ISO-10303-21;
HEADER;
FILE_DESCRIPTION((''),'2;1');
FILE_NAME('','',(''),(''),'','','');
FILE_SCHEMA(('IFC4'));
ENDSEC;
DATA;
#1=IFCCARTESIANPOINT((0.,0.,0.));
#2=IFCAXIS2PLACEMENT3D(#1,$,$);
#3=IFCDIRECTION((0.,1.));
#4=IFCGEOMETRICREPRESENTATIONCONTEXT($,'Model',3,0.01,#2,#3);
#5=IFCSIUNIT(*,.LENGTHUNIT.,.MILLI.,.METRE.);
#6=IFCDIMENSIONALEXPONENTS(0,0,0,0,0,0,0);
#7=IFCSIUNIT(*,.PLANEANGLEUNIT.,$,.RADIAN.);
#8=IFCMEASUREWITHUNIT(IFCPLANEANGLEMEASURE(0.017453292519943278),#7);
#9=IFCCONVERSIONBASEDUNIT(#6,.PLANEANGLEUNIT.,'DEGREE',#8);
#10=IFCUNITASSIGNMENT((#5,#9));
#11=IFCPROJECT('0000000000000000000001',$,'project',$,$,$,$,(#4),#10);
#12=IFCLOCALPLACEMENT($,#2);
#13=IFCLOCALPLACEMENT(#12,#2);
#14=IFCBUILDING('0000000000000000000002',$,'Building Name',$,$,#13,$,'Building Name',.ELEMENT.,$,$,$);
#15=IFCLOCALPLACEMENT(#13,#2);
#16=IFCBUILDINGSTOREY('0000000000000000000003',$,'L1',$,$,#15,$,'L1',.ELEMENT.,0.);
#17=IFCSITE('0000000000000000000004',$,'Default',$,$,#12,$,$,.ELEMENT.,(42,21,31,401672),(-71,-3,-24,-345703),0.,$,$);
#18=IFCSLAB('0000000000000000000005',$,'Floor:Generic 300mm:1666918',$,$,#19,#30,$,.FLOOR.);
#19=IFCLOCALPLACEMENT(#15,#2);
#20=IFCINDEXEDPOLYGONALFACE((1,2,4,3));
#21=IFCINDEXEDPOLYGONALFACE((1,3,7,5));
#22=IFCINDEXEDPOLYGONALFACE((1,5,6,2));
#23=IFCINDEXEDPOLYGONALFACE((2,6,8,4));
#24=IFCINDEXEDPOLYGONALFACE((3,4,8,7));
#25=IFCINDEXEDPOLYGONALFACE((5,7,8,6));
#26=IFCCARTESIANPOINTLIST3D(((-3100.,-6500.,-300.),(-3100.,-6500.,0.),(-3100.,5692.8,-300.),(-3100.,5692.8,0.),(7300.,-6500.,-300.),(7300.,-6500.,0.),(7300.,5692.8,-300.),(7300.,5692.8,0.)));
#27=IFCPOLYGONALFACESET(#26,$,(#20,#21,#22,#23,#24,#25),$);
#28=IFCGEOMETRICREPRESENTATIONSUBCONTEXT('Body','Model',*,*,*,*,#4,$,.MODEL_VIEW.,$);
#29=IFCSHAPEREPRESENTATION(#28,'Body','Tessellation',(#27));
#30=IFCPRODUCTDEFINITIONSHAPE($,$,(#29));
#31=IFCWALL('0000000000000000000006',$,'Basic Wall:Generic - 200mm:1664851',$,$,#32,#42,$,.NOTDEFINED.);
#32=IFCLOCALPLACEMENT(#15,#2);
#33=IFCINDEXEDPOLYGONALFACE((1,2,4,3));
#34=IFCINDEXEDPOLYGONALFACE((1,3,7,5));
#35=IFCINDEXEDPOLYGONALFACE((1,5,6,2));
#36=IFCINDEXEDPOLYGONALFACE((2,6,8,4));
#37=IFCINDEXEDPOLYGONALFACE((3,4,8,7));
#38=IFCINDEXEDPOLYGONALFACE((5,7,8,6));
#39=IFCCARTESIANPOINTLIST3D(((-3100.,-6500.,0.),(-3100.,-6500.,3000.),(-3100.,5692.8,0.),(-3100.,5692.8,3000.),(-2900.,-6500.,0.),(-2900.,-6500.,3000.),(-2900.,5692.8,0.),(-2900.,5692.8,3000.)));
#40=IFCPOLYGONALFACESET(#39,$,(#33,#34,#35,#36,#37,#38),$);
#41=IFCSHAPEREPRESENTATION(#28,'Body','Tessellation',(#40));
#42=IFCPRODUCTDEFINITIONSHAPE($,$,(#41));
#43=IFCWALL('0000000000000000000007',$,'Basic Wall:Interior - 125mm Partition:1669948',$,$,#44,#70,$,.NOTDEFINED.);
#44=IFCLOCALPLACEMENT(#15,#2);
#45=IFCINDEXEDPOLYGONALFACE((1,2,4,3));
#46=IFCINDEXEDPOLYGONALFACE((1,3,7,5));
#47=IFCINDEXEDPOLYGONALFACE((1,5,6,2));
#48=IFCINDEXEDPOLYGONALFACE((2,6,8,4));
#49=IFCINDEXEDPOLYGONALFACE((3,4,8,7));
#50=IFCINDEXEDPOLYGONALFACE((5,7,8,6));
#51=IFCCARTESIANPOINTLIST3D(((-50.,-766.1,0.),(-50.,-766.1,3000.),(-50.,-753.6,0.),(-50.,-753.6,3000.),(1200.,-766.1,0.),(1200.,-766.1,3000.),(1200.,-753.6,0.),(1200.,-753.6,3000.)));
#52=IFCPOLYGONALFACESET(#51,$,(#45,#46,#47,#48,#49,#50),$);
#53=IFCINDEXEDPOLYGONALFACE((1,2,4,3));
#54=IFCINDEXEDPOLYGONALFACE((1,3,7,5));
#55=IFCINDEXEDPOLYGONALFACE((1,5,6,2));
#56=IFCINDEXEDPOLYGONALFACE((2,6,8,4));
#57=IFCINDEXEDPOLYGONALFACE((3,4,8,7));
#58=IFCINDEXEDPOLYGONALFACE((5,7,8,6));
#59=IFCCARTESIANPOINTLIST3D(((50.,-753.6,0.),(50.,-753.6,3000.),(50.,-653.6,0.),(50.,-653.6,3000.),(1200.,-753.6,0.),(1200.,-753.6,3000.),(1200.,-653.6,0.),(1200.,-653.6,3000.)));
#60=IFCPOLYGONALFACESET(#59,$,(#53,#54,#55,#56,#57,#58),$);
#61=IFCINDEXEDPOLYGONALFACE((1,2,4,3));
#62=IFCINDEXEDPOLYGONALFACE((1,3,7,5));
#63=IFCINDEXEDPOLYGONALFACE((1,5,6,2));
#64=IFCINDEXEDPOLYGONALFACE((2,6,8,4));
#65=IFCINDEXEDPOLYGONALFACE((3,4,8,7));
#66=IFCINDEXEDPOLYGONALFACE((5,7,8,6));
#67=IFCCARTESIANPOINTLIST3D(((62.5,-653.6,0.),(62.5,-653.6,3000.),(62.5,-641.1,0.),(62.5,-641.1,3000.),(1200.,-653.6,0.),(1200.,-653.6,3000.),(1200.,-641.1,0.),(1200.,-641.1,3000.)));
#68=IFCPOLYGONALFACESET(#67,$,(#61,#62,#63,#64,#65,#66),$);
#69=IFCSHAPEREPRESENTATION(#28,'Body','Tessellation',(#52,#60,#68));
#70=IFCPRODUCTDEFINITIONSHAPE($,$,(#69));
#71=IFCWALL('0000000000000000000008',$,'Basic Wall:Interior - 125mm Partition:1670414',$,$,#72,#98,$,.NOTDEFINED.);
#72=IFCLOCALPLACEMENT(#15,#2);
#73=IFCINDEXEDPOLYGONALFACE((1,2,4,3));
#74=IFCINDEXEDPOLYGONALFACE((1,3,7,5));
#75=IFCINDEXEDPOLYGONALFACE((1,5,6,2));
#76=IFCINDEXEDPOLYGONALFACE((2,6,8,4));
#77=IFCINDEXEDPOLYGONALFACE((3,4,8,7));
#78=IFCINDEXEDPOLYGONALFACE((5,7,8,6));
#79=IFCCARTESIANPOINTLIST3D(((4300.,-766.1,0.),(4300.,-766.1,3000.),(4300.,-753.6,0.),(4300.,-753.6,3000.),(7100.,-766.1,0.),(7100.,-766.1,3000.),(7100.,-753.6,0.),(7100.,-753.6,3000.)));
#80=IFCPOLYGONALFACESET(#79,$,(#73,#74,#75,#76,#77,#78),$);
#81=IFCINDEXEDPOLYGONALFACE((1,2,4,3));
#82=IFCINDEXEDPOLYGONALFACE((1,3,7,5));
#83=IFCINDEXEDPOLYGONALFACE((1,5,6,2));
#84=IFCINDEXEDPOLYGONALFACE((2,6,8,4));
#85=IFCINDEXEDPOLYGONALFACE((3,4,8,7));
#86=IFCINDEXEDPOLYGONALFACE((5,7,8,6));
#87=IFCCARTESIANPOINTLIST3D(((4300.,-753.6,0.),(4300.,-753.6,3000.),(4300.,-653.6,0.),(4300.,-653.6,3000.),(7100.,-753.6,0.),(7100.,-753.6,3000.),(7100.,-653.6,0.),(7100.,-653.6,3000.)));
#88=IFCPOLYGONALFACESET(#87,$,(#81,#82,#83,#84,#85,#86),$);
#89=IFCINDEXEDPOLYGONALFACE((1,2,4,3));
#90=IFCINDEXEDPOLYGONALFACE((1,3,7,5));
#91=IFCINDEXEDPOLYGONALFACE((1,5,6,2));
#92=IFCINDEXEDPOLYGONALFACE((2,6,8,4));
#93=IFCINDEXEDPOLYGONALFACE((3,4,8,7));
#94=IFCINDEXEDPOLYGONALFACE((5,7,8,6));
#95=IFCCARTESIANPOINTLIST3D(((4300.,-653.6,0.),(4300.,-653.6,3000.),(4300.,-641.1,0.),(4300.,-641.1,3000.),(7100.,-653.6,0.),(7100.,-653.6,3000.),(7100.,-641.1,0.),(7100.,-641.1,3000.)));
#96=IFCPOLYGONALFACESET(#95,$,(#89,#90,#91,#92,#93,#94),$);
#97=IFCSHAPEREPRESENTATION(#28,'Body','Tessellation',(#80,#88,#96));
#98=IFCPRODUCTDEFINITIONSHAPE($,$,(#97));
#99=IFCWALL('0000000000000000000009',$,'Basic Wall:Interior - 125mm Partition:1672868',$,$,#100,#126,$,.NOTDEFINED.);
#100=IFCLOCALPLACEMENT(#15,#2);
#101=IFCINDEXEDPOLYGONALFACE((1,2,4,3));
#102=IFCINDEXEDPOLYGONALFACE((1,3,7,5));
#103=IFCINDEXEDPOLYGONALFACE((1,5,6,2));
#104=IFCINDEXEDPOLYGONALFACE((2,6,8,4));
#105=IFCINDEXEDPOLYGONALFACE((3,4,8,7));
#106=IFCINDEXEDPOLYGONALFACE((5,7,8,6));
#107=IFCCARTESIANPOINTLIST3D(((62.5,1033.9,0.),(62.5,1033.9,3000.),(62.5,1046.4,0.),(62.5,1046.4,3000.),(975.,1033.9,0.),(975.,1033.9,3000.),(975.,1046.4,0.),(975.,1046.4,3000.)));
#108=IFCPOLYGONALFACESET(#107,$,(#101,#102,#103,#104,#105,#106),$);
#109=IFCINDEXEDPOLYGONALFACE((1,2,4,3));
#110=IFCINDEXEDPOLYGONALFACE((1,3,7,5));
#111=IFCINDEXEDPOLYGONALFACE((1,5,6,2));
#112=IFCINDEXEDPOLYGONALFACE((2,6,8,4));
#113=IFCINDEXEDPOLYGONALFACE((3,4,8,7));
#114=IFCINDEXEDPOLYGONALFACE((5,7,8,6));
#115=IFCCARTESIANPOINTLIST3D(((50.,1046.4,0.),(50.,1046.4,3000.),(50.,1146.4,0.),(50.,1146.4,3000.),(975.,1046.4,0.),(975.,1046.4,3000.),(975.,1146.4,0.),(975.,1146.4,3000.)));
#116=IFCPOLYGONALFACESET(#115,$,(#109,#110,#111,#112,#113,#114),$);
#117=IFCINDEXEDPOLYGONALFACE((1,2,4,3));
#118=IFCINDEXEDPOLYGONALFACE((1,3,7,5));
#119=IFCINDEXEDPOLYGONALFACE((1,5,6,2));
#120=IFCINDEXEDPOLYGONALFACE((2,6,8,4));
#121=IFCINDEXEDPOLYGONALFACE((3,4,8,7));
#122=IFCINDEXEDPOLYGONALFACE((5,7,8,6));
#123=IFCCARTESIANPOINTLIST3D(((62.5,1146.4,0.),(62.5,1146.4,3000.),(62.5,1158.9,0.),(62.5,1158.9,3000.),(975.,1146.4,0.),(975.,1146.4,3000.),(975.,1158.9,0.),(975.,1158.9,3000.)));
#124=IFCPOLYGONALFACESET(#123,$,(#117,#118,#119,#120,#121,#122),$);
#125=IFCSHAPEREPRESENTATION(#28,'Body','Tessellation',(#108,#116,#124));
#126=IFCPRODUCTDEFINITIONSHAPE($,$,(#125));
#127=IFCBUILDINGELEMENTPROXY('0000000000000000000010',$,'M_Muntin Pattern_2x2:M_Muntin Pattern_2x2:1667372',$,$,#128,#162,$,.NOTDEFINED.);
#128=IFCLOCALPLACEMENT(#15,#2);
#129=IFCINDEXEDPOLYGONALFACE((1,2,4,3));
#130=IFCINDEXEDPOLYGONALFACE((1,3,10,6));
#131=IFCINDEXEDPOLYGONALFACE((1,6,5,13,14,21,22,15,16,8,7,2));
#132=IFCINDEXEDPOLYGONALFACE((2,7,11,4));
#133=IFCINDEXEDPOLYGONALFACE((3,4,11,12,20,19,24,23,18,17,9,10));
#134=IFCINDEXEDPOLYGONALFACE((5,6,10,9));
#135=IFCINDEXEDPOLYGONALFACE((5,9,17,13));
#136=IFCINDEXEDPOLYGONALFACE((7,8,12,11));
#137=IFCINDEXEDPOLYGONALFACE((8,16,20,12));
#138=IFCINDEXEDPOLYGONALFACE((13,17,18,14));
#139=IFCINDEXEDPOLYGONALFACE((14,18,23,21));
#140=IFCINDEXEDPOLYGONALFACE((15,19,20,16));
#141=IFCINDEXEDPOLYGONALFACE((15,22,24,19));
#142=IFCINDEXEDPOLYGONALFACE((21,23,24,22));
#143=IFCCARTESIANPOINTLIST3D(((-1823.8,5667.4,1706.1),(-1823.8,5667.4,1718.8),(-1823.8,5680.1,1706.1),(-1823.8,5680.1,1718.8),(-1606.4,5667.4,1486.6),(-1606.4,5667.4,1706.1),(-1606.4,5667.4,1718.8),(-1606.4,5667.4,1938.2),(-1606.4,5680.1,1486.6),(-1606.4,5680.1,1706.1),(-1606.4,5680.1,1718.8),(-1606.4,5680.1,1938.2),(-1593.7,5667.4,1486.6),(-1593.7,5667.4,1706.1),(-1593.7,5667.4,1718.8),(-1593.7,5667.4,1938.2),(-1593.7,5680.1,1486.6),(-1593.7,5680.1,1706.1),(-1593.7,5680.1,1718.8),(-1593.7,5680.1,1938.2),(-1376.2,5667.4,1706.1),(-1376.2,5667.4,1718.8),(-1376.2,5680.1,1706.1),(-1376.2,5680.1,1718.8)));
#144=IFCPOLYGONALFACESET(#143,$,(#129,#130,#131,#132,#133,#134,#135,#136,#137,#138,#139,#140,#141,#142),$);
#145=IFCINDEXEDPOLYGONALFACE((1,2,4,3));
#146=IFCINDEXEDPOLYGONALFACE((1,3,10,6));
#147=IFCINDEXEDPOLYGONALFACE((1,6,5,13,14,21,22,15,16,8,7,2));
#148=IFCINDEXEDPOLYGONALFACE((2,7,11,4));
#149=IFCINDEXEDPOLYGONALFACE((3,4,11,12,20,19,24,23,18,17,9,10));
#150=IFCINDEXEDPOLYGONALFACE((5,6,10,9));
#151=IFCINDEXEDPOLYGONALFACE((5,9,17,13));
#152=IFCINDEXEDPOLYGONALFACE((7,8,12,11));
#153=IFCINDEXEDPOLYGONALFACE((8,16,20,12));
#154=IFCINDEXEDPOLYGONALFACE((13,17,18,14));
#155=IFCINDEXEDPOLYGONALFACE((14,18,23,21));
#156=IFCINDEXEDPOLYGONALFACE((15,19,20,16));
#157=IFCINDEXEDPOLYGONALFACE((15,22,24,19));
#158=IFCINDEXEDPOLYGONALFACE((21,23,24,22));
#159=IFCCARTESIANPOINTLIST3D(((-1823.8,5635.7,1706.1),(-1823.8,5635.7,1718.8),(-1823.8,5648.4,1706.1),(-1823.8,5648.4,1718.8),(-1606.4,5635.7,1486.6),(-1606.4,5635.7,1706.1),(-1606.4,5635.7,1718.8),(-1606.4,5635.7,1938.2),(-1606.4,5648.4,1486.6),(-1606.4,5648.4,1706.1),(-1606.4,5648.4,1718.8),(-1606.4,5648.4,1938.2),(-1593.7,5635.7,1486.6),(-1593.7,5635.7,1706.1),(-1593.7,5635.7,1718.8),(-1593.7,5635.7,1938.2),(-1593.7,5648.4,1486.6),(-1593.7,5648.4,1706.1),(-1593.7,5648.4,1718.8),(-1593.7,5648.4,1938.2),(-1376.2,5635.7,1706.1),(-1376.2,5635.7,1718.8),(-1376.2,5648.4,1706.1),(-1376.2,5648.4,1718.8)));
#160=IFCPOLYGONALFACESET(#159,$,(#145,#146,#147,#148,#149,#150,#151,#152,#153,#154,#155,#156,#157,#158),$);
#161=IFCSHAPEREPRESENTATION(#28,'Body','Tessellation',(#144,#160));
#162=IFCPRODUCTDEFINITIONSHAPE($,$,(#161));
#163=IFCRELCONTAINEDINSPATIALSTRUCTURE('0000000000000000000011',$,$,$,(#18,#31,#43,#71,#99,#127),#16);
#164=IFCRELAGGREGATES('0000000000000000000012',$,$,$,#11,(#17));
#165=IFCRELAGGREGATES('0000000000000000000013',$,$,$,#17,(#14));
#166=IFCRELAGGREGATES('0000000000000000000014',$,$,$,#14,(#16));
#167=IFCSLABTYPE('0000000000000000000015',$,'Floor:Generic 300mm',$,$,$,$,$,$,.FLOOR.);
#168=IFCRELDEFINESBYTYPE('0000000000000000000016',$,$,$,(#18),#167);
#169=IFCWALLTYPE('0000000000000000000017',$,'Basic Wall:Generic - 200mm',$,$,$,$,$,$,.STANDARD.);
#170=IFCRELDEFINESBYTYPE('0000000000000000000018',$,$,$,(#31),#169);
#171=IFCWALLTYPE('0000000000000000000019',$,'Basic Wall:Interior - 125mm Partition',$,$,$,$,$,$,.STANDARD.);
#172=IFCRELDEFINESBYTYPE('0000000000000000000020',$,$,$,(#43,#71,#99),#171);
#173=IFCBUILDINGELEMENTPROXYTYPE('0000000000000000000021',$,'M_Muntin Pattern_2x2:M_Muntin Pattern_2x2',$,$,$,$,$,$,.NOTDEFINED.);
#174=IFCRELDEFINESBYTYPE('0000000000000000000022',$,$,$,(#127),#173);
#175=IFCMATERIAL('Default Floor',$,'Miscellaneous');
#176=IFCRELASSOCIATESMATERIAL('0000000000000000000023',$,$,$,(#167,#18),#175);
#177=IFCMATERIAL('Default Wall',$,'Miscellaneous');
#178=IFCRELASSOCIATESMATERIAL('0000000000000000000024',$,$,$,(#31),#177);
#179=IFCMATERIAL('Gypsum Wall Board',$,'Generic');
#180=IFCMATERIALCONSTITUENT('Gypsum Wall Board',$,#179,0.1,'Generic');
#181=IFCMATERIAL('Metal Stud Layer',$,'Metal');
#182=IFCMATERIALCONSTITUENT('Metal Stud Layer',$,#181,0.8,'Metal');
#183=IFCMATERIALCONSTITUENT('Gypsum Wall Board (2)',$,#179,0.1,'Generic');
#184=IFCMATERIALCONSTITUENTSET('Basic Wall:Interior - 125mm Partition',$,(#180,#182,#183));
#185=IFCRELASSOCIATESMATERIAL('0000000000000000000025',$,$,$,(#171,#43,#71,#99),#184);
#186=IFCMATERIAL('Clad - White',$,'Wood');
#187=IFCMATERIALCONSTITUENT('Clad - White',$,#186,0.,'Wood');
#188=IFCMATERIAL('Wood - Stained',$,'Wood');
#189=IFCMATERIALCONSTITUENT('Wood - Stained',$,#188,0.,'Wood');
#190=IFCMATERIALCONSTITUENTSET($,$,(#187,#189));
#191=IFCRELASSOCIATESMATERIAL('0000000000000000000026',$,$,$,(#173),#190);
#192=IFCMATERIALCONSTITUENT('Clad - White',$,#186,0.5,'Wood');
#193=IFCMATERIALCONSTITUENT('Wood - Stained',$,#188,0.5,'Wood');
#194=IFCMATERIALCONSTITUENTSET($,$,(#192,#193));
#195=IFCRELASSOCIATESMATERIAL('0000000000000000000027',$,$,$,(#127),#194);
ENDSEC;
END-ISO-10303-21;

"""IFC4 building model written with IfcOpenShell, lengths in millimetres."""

from ifc_helpers import new_model, entity, si_unit, converted_unit, direction, frame, origin, place, context, subcontext, project, spatial, indexed_curve, outline, extrude, source, transform, mapped, material, constituent, constituent_set, type_object, type_shapes, element, save


model = new_model("IFC4")

# Units and contexts
model_context = context("Model", 3, precision=0.01, world=origin(), true_north=direction((0.0, 1.0)))
body_context = subcontext(model_context, "Body", "Model", "MODEL_VIEW")
ifc_project = project(units=[si_unit("LENGTHUNIT", "METRE", prefix="MILLI"), converted_unit("PLANEANGLEUNIT", "DEGREE", entity("IfcPlaneAngleMeasure", 0.017453292519943278), si_unit("PLANEANGLEUNIT", "RADIAN"), dimensions=[0, 0, 0, 0, 0, 0, 0])], contexts=[model_context])

# Site, building, storey
site_placement = place(None, origin())
site = spatial("IfcSite", under=ifc_project, at=site_placement, Name="Default", CompositionType="ELEMENT", RefLatitude=(42, 21, 31, 401672), RefLongitude=(-71, -3, -24, -345703), RefElevation=0.0)
building_placement = place(site_placement, origin())
building = spatial("IfcBuilding", under=site, at=building_placement, Name="Building Name", LongName="Building Name", CompositionType="ELEMENT")
storey_placement = place(building_placement, origin())
storey = spatial("IfcBuildingStorey", under=building, at=storey_placement, Name="L1", LongName="L1", CompositionType="ELEMENT", Elevation=0.0)

# Slab
ifc_material_1 = material(Name="Default Floor", Category="Miscellaneous")
slab_type = type_object("IfcSlabType", Name="Floor:Generic 300mm", PredefinedType="FLOOR", material=ifc_material_1)
slab_placement = place(storey_placement, origin())
element("IfcSlab", 1, at=slab_placement, inside=storey, type_object=slab_type, material=ifc_material_1, Name="Floor:Generic 300mm:1666918", PredefinedType="FLOOR", context=body_context, shape_type="SweptSolid", body=[
    extrude(outline(indexed_curve([(-6096.4, -5200.0), (6096.4, -5200.0), (6096.4, 5200.0), (-6096.4, 5200.0), (-6096.4, -5200.0)], self_intersect=False)), frame((2100.0, -403.6, 0.0), z_axis=(0.0, 0.0, -1.0), x_axis=(0.0, 1.0, 0.0)), (0.0, 0.0, 1.0), 300.0),
])

# Wall
ifc_material_2 = material(Name="Default Wall", Category="Miscellaneous")
wall_type_1 = type_object("IfcWallType", Name="Basic Wall:Generic - 200mm", PredefinedType="STANDARD")
wall_1_placement = place(storey_placement, frame((-3000.0, 5692.8, 0.0), z_axis=(0.0, 0.0, 1.0), x_axis=(0.0, -1.0, 0.0)))
element("IfcWall", 2, at=wall_1_placement, inside=storey, type_object=wall_type_1, material=ifc_material_2, Name="Basic Wall:Generic - 200mm:1664851", PredefinedType="NOTDEFINED", context=body_context, shape_type="SweptSolid", body=[
    extrude(outline(indexed_curve([(12192.8, 100.0), (0.0, 100.0), (0.0, -100.0), (12192.8, -100.0), (12192.8, 100.0)], self_intersect=False)), origin(), (0.0, 0.0, 1.0), 3000.0),
])

# Shared definitions
ifc_material_3 = material(Name="Gypsum Wall Board", Category="Generic")
ifc_constituent_1 = constituent(ifc_material_3, Name="Gypsum Wall Board", Category="Generic", fraction=0.1)
ifc_material_4 = material(Name="Metal Stud Layer", Category="Metal")
ifc_constituent_2 = constituent(ifc_material_4, Name="Metal Stud Layer", Category="Metal", fraction=0.8)
ifc_constituent_3 = constituent(ifc_material_3, Name="Gypsum Wall Board (2)", Category="Generic", fraction=0.1)
ifc_constituent_set_1 = constituent_set(constituents=[ifc_constituent_1, ifc_constituent_2, ifc_constituent_3], Name="Basic Wall:Interior - 125mm Partition")
wall_type_2 = type_object("IfcWallType", Name="Basic Wall:Interior - 125mm Partition", PredefinedType="STANDARD", material=ifc_constituent_set_1)

# Walls
wall_2_placement = place(storey_placement, frame((62.5, -703.6, 0.0)))
element("IfcWall", 3, at=wall_2_placement, inside=storey, type_object=wall_type_2, material=ifc_constituent_set_1, Name="Basic Wall:Interior - 125mm Partition:1669948", PredefinedType="NOTDEFINED", context=body_context, shape_type="SweptSolid", body=[
    extrude(outline(indexed_curve([(-6.3, -625.0), (6.2, -625.0), (6.3, 625.0), (-6.2, 625.0), (-6.3, -625.0)], self_intersect=False)), frame((512.5, -56.2, 0.0), z_axis=(0.0, 0.0, 1.0), x_axis=(0.0, 1.0, 0.0)), (0.0, 0.0, 1.0), 3000.0),
    extrude(outline(indexed_curve([(-575.0, -50.0), (575.0, -50.0), (575.0, 50.0), (-575.0, 50.0), (-575.0, -50.0)], self_intersect=False)), frame((562.5, 0.0, 0.0)), (0.0, 0.0, 1.0), 3000.0),
    extrude(outline(indexed_curve([(-6.3, -568.7), (6.2, -568.7), (6.3, 568.7), (-6.2, 568.7), (-6.3, -568.7)], self_intersect=False)), frame((568.7, 56.3, 0.0), z_axis=(0.0, 0.0, 1.0), x_axis=(0.0, -1.0, 0.0)), (0.0, 0.0, 1.0), 3000.0),
])
wall_3_placement = place(storey_placement, frame((7100.0, -703.6, 0.0), z_axis=(0.0, 0.0, 1.0), x_axis=(-1.0, 0.0, 0.0)))
element("IfcWall", 4, at=wall_3_placement, inside=storey, type_object=wall_type_2, material=ifc_constituent_set_1, Name="Basic Wall:Interior - 125mm Partition:1670414", PredefinedType="NOTDEFINED", context=body_context, shape_type="SweptSolid", body=[
    extrude(outline(indexed_curve([(-6.2, -1400.0), (6.3, -1400.0), (6.2, 1400.0), (-6.3, 1400.0), (-6.2, -1400.0)], self_intersect=False)), frame((1400.0, 56.3, 0.0), z_axis=(0.0, 0.0, 1.0), x_axis=(0.0, -1.0, 0.0)), (0.0, 0.0, 1.0), 3000.0),
    extrude(outline(indexed_curve([(-1400.0, -50.0), (1400.0, -50.0), (1400.0, 50.0), (-1400.0, 50.0), (-1400.0, -50.0)], self_intersect=False)), frame((1400.0, 0.0, 0.0)), (0.0, 0.0, 1.0), 3000.0),
    extrude(outline(indexed_curve([(-6.3, -1400.0), (6.2, -1400.0), (6.2, 1400.0), (-6.3, 1400.0), (-6.3, -1400.0)], self_intersect=False)), frame((1400.0, -56.2, 0.0), z_axis=(0.0, 0.0, 1.0), x_axis=(0.0, 1.0, 0.0)), (0.0, 0.0, 1.0), 3000.0),
])

# Wall
wall_4_placement = place(storey_placement, frame((62.5, 1096.4, 0.0)))
element("IfcWall", 5, at=wall_4_placement, inside=storey, type_object=wall_type_2, material=ifc_constituent_set_1, Name="Basic Wall:Interior - 125mm Partition:1672868", PredefinedType="NOTDEFINED", context=body_context, shape_type="SweptSolid", body=[
    extrude(outline(indexed_curve([(-6.3, -456.2), (6.2, -456.2), (6.3, 456.2), (-6.2, 456.2), (-6.3, -456.2)], self_intersect=False)), frame((456.2, -56.3, 0.0), z_axis=(0.0, 0.0, 1.0), x_axis=(0.0, 1.0, 0.0)), (0.0, 0.0, 1.0), 3000.0),
    extrude(outline(indexed_curve([(-462.5, -50.0), (462.5, -50.0), (462.5, 50.0), (-462.5, 50.0), (-462.5, -50.0)], self_intersect=False)), frame((450.0, 0.0, 0.0)), (0.0, 0.0, 1.0), 3000.0),
    extrude(outline(indexed_curve([(-6.3, -456.2), (6.2, -456.2), (6.3, 456.2), (-6.2, 456.2), (-6.3, -456.2)], self_intersect=False)), frame((456.2, 56.2, 0.0), z_axis=(0.0, 0.0, 1.0), x_axis=(0.0, -1.0, 0.0)), (0.0, 0.0, 1.0), 3000.0),
])

# Building element proxy
ifc_material_5 = material(Name="Clad - White", Category="Wood")
ifc_constituent_4 = constituent(ifc_material_5, Name="Clad - White", Category="Wood", fraction=0.5)
ifc_material_6 = material(Name="Wood - Stained", Category="Wood")
ifc_constituent_5 = constituent(ifc_material_6, Name="Wood - Stained", Category="Wood", fraction=0.5)
ifc_constituent_set_2 = constituent_set(constituents=[ifc_constituent_4, ifc_constituent_5])
ifc_constituent_6 = constituent(ifc_material_5, Name="Clad - White", Category="Wood", fraction=0.0)
ifc_constituent_7 = constituent(ifc_material_6, Name="Wood - Stained", Category="Wood", fraction=0.0)
ifc_constituent_set_3 = constituent_set(constituents=[ifc_constituent_6, ifc_constituent_7])
building_element_proxy_type_1 = type_object("IfcBuildingElementProxyType", Name="M_Muntin Pattern_2x2:M_Muntin Pattern_2x2", PredefinedType="NOTDEFINED", material=ifc_constituent_set_3)
shared_shape_1 = source(origin(), body_context, "Body", "SweptSolid", [
    extrude(outline(indexed_curve([(6.4, -6.4), (225.8, -6.4), (225.8, 6.3), (6.4, 6.3), (6.4, 223.8), (-6.3, 223.8), (-6.3, 6.3), (-225.8, 6.3), (-225.8, -6.4), (-6.3, -6.4), (-6.3, -223.8), (6.4, -223.8), (6.4, -6.4)], self_intersect=False)), frame((0.0, 9.5, 225.8), z_axis=(0.0, 1.0, 0.0), x_axis=(0.0, 0.0, 1.0)), (0.0, 0.0, 1.0), 12.7),
    extrude(outline(indexed_curve([(6.4, -6.4), (225.8, -6.4), (225.8, 6.3), (6.4, 6.3), (6.4, 223.8), (-6.3, 223.8), (-6.3, 6.3), (-225.8, 6.3), (-225.8, -6.4), (-6.3, -6.4), (-6.3, -223.8), (6.4, -223.8), (6.4, -6.4)], self_intersect=False)), frame((0.0, -22.2, 225.8), z_axis=(0.0, 1.0, 0.0), x_axis=(0.0, 0.0, 1.0)), (0.0, 0.0, 1.0), 12.7),
])
type_shapes(building_element_proxy_type_1, [shared_shape_1])
proxy_1_placement = place(storey_placement, frame((-1600.0, 5657.9, 1486.6)))
element("IfcBuildingElementProxy", 6, at=proxy_1_placement, inside=storey, type_object=building_element_proxy_type_1, material=ifc_constituent_set_2, Name="M_Muntin Pattern_2x2:M_Muntin Pattern_2x2:1667372", PredefinedType="NOTDEFINED", context=body_context, shape_type="MappedRepresentation", body=[
    mapped(shared_shape_1, transform((0.0, 0.0, 0.0), scale=1.0)),
])

save(model, "model.ifc")
